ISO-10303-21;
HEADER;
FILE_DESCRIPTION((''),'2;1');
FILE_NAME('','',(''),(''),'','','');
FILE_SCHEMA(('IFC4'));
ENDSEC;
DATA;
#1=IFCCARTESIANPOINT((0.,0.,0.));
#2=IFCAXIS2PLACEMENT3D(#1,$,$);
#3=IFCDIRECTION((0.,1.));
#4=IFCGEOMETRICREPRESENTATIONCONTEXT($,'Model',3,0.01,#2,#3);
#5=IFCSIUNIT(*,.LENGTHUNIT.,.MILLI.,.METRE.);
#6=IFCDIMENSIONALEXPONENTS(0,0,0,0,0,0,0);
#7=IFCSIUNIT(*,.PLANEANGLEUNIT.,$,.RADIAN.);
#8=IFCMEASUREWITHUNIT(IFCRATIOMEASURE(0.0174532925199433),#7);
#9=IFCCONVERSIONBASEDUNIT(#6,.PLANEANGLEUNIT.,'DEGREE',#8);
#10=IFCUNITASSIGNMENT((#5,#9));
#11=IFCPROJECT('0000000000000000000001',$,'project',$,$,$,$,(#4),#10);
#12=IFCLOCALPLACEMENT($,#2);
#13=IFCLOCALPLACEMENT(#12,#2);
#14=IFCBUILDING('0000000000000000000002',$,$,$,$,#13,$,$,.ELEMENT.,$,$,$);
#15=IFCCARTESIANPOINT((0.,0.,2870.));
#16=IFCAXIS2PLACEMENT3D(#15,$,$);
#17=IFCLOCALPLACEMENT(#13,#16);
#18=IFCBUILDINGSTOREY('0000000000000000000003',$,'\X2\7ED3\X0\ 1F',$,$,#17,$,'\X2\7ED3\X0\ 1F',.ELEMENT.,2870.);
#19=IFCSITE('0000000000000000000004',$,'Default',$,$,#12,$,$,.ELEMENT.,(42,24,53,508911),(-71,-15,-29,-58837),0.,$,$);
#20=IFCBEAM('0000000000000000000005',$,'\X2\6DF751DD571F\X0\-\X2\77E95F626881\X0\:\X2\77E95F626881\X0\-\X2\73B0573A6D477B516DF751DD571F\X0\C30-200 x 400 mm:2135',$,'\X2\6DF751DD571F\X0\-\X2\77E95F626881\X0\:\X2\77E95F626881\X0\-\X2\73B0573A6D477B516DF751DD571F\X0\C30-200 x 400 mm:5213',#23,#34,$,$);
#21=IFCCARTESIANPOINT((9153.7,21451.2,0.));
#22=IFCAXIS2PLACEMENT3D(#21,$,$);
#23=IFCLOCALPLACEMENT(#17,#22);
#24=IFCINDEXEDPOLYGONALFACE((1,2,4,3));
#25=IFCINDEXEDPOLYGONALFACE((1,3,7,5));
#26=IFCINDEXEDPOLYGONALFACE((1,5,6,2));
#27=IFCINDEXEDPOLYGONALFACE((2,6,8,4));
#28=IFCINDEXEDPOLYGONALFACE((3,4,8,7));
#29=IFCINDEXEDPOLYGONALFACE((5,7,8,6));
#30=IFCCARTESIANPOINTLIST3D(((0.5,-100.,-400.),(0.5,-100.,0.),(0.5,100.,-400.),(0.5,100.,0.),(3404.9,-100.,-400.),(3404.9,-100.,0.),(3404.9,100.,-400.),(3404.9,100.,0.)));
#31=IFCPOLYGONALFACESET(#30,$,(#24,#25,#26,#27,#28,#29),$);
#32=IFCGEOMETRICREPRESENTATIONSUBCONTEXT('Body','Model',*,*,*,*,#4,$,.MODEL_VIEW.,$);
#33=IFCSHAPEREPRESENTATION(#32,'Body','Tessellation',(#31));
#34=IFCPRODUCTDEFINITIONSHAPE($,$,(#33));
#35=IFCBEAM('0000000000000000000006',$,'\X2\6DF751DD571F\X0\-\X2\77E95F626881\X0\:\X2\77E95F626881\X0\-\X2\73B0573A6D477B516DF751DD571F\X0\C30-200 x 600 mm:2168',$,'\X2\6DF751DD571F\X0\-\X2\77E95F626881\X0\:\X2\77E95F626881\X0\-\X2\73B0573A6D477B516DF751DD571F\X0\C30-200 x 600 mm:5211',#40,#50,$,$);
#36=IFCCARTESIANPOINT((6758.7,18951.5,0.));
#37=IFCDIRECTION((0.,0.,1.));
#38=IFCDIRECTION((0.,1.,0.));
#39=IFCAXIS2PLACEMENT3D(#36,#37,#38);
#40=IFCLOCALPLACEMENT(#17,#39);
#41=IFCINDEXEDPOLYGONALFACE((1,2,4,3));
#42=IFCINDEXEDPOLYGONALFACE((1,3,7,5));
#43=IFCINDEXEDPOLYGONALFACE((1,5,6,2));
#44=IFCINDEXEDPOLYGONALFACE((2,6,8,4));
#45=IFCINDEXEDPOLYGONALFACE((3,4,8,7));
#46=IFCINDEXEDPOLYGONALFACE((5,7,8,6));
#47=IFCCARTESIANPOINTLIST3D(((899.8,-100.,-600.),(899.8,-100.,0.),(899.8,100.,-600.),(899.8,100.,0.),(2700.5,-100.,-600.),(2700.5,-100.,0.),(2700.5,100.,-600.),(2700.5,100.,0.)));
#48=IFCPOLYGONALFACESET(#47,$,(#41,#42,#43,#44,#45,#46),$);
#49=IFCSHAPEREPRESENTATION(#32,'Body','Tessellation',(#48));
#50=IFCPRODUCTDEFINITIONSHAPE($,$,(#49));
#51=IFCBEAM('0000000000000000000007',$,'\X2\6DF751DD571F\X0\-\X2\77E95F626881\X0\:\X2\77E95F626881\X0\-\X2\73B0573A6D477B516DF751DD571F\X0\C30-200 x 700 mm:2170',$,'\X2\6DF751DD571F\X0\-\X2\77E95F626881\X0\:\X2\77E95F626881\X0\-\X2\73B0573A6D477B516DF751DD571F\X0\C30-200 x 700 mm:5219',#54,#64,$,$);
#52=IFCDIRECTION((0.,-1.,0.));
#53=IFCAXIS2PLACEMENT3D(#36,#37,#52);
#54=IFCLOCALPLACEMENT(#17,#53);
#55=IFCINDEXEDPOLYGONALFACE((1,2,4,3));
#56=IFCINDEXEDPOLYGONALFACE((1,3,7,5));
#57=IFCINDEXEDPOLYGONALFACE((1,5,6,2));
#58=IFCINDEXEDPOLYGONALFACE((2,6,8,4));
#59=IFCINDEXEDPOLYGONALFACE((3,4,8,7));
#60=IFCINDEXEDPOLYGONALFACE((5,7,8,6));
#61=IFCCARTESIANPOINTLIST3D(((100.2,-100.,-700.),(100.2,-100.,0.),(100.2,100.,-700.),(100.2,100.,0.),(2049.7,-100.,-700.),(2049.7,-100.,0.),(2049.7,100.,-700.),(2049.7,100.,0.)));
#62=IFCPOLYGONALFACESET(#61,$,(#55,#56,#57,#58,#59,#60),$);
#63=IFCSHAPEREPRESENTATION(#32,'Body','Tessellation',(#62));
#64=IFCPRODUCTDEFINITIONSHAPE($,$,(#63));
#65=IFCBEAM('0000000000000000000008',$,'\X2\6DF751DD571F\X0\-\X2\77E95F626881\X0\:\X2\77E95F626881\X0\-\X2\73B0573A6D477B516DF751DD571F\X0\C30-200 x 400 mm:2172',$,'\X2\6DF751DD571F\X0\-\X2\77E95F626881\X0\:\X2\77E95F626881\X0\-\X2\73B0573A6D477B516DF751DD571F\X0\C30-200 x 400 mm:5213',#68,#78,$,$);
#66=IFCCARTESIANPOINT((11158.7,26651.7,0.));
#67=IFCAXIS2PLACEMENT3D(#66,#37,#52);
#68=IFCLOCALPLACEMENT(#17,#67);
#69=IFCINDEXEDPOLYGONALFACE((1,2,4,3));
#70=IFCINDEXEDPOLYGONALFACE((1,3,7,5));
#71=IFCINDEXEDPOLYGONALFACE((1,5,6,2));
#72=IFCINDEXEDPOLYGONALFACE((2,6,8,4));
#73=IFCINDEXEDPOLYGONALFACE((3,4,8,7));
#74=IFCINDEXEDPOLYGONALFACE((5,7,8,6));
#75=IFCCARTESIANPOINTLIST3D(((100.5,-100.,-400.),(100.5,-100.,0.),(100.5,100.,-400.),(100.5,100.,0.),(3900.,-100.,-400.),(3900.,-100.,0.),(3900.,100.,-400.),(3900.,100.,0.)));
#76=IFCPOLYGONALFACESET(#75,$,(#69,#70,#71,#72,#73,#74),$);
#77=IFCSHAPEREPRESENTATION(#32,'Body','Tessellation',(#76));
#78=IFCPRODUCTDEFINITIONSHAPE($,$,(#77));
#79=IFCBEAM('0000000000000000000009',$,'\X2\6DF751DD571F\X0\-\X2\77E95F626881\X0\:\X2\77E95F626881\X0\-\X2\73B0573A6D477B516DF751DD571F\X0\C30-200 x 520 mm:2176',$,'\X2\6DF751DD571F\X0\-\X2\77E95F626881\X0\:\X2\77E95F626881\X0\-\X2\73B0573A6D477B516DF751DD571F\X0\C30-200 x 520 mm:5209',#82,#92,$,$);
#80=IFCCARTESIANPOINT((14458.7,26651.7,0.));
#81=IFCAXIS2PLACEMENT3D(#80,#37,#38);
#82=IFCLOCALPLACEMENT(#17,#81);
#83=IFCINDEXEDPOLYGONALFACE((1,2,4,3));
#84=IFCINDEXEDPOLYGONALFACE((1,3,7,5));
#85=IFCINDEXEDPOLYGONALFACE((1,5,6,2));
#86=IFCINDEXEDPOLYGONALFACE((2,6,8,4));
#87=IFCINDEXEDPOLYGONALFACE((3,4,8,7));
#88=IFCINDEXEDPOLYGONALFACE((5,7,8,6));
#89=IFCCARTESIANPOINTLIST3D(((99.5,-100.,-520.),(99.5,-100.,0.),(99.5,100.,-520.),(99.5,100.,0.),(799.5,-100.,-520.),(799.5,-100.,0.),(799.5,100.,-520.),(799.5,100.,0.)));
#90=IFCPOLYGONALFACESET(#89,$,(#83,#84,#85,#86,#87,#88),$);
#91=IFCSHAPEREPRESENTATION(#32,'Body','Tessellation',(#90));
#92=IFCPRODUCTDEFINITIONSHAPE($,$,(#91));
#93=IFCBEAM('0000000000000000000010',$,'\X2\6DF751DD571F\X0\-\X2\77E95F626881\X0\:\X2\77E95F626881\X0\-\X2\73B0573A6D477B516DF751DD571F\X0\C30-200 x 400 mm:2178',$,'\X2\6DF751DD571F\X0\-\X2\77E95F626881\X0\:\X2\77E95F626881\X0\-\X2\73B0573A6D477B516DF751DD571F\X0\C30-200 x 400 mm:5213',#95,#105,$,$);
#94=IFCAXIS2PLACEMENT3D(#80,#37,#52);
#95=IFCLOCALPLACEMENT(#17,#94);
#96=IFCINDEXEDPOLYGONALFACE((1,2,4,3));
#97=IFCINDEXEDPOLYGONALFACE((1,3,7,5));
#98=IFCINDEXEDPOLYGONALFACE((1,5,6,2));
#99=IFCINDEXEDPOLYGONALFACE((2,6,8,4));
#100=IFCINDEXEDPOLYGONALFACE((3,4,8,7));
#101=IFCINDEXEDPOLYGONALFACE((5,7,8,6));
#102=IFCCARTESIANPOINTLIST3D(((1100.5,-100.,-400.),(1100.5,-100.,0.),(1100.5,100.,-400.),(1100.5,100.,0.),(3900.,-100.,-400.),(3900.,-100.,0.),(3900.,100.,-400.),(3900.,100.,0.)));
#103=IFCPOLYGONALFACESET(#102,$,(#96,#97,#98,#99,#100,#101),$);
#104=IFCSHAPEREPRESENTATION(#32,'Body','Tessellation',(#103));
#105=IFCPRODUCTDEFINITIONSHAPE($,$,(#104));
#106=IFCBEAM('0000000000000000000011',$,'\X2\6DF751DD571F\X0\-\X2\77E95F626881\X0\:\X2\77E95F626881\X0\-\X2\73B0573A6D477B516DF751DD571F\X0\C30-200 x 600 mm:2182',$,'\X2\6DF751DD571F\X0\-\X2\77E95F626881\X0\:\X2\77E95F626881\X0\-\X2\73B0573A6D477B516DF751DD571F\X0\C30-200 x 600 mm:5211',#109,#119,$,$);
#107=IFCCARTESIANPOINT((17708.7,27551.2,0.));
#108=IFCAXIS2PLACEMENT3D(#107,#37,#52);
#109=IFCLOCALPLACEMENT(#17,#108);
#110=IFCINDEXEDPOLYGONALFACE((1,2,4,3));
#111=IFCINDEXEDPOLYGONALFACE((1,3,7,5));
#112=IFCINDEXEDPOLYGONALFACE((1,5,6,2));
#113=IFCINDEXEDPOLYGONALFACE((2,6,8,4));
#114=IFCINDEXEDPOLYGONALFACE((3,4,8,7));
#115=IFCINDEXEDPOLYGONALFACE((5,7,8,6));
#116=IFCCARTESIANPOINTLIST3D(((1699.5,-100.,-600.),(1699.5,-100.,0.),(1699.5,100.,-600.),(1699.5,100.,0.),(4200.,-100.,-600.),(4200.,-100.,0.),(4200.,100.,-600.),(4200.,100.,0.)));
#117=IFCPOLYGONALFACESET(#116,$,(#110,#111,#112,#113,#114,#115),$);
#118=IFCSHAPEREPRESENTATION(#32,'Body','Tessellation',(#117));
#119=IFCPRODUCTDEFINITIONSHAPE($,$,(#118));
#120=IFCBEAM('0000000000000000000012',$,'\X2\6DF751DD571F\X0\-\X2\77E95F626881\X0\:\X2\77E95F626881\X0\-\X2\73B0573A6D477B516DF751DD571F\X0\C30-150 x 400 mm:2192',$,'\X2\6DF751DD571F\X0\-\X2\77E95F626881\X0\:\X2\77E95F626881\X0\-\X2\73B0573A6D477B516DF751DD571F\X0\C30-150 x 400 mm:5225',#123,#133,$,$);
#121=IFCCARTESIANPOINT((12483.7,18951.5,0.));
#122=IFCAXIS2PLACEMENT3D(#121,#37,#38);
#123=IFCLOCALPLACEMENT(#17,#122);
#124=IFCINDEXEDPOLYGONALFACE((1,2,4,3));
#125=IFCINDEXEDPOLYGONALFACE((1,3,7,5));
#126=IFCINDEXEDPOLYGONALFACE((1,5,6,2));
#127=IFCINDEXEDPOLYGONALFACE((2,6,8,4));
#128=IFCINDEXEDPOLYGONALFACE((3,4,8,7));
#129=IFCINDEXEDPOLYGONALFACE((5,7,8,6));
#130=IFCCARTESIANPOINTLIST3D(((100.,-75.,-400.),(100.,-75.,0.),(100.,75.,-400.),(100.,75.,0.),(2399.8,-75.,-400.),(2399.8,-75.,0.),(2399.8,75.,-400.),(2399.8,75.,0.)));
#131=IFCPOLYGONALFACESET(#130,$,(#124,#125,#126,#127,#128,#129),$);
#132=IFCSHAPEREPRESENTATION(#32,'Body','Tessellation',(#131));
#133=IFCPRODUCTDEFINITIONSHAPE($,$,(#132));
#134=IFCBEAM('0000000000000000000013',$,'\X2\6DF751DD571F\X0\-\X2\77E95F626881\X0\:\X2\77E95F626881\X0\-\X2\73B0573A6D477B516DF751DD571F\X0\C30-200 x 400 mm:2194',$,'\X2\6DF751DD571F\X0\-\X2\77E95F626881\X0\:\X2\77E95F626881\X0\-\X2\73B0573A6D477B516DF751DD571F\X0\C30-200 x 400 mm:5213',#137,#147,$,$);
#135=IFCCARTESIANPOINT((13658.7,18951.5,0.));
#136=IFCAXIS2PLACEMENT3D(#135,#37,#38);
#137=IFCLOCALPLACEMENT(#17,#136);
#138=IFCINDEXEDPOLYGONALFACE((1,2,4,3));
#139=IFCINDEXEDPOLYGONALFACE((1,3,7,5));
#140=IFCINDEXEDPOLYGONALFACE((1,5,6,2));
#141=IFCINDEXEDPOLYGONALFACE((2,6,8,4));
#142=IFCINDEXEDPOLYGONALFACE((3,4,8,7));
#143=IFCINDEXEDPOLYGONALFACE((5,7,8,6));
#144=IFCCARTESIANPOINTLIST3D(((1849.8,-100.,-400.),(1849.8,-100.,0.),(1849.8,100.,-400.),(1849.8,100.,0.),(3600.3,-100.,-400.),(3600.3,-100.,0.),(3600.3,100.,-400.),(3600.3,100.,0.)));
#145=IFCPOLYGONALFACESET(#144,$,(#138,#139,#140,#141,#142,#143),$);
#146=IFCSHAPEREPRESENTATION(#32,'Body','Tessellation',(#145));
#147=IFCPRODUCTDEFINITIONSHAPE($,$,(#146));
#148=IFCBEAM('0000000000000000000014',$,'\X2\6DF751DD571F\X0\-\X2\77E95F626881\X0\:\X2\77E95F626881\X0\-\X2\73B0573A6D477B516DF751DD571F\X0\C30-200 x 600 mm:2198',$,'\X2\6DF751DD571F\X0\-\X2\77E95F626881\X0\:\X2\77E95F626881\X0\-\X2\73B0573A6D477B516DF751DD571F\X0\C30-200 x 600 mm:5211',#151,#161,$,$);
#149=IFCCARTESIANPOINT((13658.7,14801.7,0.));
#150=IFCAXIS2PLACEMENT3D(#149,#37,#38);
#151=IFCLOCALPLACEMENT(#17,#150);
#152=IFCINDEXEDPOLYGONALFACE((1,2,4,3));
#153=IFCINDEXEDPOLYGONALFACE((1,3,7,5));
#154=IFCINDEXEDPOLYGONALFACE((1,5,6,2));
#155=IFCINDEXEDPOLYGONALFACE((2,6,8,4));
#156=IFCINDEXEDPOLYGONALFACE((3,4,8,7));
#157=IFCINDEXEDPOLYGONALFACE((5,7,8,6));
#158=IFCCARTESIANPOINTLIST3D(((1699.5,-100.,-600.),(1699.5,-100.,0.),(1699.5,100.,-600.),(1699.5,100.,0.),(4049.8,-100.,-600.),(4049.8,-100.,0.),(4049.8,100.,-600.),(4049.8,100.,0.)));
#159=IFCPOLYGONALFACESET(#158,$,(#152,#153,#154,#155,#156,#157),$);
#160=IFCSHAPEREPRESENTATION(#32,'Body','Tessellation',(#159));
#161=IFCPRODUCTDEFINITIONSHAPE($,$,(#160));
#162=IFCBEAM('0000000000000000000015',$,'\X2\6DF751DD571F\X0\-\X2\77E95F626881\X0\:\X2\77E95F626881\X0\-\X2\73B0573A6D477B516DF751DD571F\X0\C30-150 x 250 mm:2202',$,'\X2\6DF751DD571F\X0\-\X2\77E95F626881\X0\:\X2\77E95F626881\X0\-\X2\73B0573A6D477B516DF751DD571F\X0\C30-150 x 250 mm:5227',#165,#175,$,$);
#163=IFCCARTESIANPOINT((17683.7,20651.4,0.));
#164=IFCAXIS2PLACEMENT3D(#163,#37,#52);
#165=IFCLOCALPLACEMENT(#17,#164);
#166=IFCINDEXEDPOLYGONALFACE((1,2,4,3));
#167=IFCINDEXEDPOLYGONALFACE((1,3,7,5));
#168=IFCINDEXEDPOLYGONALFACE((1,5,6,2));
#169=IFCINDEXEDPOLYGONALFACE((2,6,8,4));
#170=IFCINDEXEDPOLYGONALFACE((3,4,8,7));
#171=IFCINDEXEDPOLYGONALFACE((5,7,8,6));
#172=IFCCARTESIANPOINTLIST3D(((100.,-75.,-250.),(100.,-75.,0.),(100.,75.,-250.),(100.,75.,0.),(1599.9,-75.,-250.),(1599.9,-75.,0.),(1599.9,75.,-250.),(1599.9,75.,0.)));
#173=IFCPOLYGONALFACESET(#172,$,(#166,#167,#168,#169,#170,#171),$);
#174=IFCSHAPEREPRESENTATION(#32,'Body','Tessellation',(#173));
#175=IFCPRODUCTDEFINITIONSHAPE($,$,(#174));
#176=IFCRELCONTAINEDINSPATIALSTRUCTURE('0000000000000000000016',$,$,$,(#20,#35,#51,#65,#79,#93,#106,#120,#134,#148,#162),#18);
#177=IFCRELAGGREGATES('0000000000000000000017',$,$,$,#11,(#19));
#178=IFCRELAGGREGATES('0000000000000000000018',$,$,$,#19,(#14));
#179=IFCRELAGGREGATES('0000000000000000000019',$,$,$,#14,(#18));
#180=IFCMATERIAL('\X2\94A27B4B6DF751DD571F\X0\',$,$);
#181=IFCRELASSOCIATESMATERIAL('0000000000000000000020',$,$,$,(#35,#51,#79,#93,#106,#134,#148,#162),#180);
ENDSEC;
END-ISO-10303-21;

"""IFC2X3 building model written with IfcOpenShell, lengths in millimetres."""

from ifc_helpers import new_model, entity, si_unit, converted_unit, direction, frame, frame_2d, origin, place, context, subcontext, project, spatial, rectangle, extrude, material, element, save


model = new_model("IFC2X3")

# Units and contexts
model_context = context("Model", 3, precision=0.01, world=origin(), true_north=direction((0.0, 1.0)))
body_context = subcontext(model_context, "Body", "Model", "MODEL_VIEW")
ifc_project = project(units=[si_unit("LENGTHUNIT", "METRE", prefix="MILLI"), converted_unit("PLANEANGLEUNIT", "DEGREE", entity("IfcRatioMeasure", 0.0174532925199433), si_unit("PLANEANGLEUNIT", "RADIAN"), dimensions=[0, 0, 0, 0, 0, 0, 0])], contexts=[model_context])

# Site, building, storey
site_placement = place(None, origin())
site = spatial("IfcSite", under=ifc_project, at=site_placement, Name="Default", CompositionType="ELEMENT", RefLatitude=(42, 24, 53, 508911), RefLongitude=(-71, -15, -29, -58837), RefElevation=0.0)
building_placement = place(site_placement, origin())
building = spatial("IfcBuilding", under=site, at=building_placement, CompositionType="ELEMENT")
storey_placement = place(building_placement, frame((0.0, 0.0, 2870.0)))
storey = spatial("IfcBuildingStorey", under=building, at=storey_placement, Name="结 1F", LongName="结 1F", CompositionType="ELEMENT", Elevation=2870.0)

# Beams
ifc_material = material(Name="钢筋混凝土")
beam_1_placement = place(storey_placement, frame((9153.7, 21451.2, 0.0)))
element("IfcBeam", 1, at=beam_1_placement, inside=storey, Name="混凝土-矩形梁:矩形梁-现场浇筑混凝土C30-200 x 400 mm:2135", ObjectType="混凝土-矩形梁:矩形梁-现场浇筑混凝土C30-200 x 400 mm:5213", context=body_context, shape_type="SweptSolid", body=[
    extrude(rectangle(XDim=400.0, YDim=200.0, at=frame_2d((0.0, 0.0), x_axis=(1.0, 0.0))), frame((0.5, 0.0, -200.0), z_axis=(1.0, 0.0, 0.0), x_axis=(0.0, 0.0, -1.0)), (0.0, 0.0, 1.0), 3404.5),
])
beam_2_placement = place(storey_placement, frame((6758.7, 18951.5, 0.0), z_axis=(0.0, 0.0, 1.0), x_axis=(0.0, 1.0, 0.0)))
element("IfcBeam", 2, at=beam_2_placement, inside=storey, material=ifc_material, Name="混凝土-矩形梁:矩形梁-现场浇筑混凝土C30-200 x 600 mm:2168", ObjectType="混凝土-矩形梁:矩形梁-现场浇筑混凝土C30-200 x 600 mm:5211", context=body_context, shape_type="SweptSolid", body=[
    extrude(rectangle(XDim=600.0, YDim=200.0, at=frame_2d((0.0, 0.0), x_axis=(1.0, 0.0))), frame((899.8, 0.0, -300.0), z_axis=(1.0, 0.0, 0.0), x_axis=(0.0, 0.0, -1.0)), (0.0, 0.0, 1.0), 1800.7),
])
beam_3_placement = place(storey_placement, frame((6758.7, 18951.5, 0.0), z_axis=(0.0, 0.0, 1.0), x_axis=(0.0, -1.0, 0.0)))
element("IfcBeam", 3, at=beam_3_placement, inside=storey, material=ifc_material, Name="混凝土-矩形梁:矩形梁-现场浇筑混凝土C30-200 x 700 mm:2170", ObjectType="混凝土-矩形梁:矩形梁-现场浇筑混凝土C30-200 x 700 mm:5219", context=body_context, shape_type="SweptSolid", body=[
    extrude(rectangle(XDim=700.0, YDim=200.0, at=frame_2d((0.0, 0.0), x_axis=(1.0, 0.0))), frame((100.2, 0.0, -350.0), z_axis=(1.0, 0.0, 0.0), x_axis=(0.0, 0.0, -1.0)), (0.0, 0.0, 1.0), 1949.5),
])
beam_4_placement = place(storey_placement, frame((11158.7, 26651.7, 0.0), z_axis=(0.0, 0.0, 1.0), x_axis=(0.0, -1.0, 0.0)))
element("IfcBeam", 4, at=beam_4_placement, inside=storey, Name="混凝土-矩形梁:矩形梁-现场浇筑混凝土C30-200 x 400 mm:2172", ObjectType="混凝土-矩形梁:矩形梁-现场浇筑混凝土C30-200 x 400 mm:5213", context=body_context, shape_type="SweptSolid", body=[
    extrude(rectangle(XDim=400.0, YDim=200.0, at=frame_2d((0.0, 0.0), x_axis=(1.0, 0.0))), frame((100.5, 0.0, -200.0), z_axis=(1.0, 0.0, 0.0), x_axis=(0.0, 0.0, -1.0)), (0.0, 0.0, 1.0), 3799.5),
])
beam_5_placement = place(storey_placement, frame((14458.7, 26651.7, 0.0), z_axis=(0.0, 0.0, 1.0), x_axis=(0.0, 1.0, 0.0)))
element("IfcBeam", 5, at=beam_5_placement, inside=storey, material=ifc_material, Name="混凝土-矩形梁:矩形梁-现场浇筑混凝土C30-200 x 520 mm:2176", ObjectType="混凝土-矩形梁:矩形梁-现场浇筑混凝土C30-200 x 520 mm:5209", context=body_context, shape_type="SweptSolid", body=[
    extrude(rectangle(XDim=520.0, YDim=200.0, at=frame_2d((0.0, 0.0), x_axis=(1.0, 0.0))), frame((99.5, 0.0, -260.0), z_axis=(1.0, 0.0, 0.0), x_axis=(0.0, 0.0, -1.0)), (0.0, 0.0, 1.0), 700.0),
])
beam_6_placement = place(storey_placement, frame((14458.7, 26651.7, 0.0), z_axis=(0.0, 0.0, 1.0), x_axis=(0.0, -1.0, 0.0)))
element("IfcBeam", 6, at=beam_6_placement, inside=storey, material=ifc_material, Name="混凝土-矩形梁:矩形梁-现场浇筑混凝土C30-200 x 400 mm:2178", ObjectType="混凝土-矩形梁:矩形梁-现场浇筑混凝土C30-200 x 400 mm:5213", context=body_context, shape_type="SweptSolid", body=[
    extrude(rectangle(XDim=400.0, YDim=200.0, at=frame_2d((0.0, 0.0), x_axis=(1.0, 0.0))), frame((1100.5, 0.0, -200.0), z_axis=(1.0, 0.0, 0.0), x_axis=(0.0, 0.0, -1.0)), (0.0, 0.0, 1.0), 2799.5),
])
beam_7_placement = place(storey_placement, frame((17708.7, 27551.2, 0.0), z_axis=(0.0, 0.0, 1.0), x_axis=(0.0, -1.0, 0.0)))
element("IfcBeam", 7, at=beam_7_placement, inside=storey, material=ifc_material, Name="混凝土-矩形梁:矩形梁-现场浇筑混凝土C30-200 x 600 mm:2182", ObjectType="混凝土-矩形梁:矩形梁-现场浇筑混凝土C30-200 x 600 mm:5211", context=body_context, shape_type="SweptSolid", body=[
    extrude(rectangle(XDim=600.0, YDim=200.0, at=frame_2d((0.0, 0.0), x_axis=(1.0, 0.0))), frame((1699.5, 0.0, -300.0), z_axis=(1.0, 0.0, 0.0), x_axis=(0.0, 0.0, -1.0)), (0.0, 0.0, 1.0), 2500.5),
])
beam_8_placement = place(storey_placement, frame((12483.7, 18951.5, 0.0), z_axis=(0.0, 0.0, 1.0), x_axis=(0.0, 1.0, 0.0)))
element("IfcBeam", 8, at=beam_8_placement, inside=storey, Name="混凝土-矩形梁:矩形梁-现场浇筑混凝土C30-150 x 400 mm:2192", ObjectType="混凝土-矩形梁:矩形梁-现场浇筑混凝土C30-150 x 400 mm:5225", context=body_context, shape_type="SweptSolid", body=[
    extrude(rectangle(XDim=400.0, YDim=150.0, at=frame_2d((0.0, 0.0), x_axis=(1.0, 0.0))), frame((100.0, 0.0, -200.0), z_axis=(1.0, 0.0, 0.0), x_axis=(0.0, 0.0, -1.0)), (0.0, 0.0, 1.0), 2299.8),
])
beam_9_placement = place(storey_placement, frame((13658.7, 18951.5, 0.0), z_axis=(0.0, 0.0, 1.0), x_axis=(0.0, 1.0, 0.0)))
element("IfcBeam", 9, at=beam_9_placement, inside=storey, material=ifc_material, Name="混凝土-矩形梁:矩形梁-现场浇筑混凝土C30-200 x 400 mm:2194", ObjectType="混凝土-矩形梁:矩形梁-现场浇筑混凝土C30-200 x 400 mm:5213", context=body_context, shape_type="SweptSolid", body=[
    extrude(rectangle(XDim=400.0, YDim=200.0, at=frame_2d((0.0, 0.0), x_axis=(1.0, 0.0))), frame((1849.8, 0.0, -200.0), z_axis=(1.0, 0.0, 0.0), x_axis=(0.0, 0.0, -1.0)), (0.0, 0.0, 1.0), 1750.5),
])
beam_10_placement = place(storey_placement, frame((13658.7, 14801.7, 0.0), z_axis=(0.0, 0.0, 1.0), x_axis=(0.0, 1.0, 0.0)))
element("IfcBeam", 10, at=beam_10_placement, inside=storey, material=ifc_material, Name="混凝土-矩形梁:矩形梁-现场浇筑混凝土C30-200 x 600 mm:2198", ObjectType="混凝土-矩形梁:矩形梁-现场浇筑混凝土C30-200 x 600 mm:5211", context=body_context, shape_type="SweptSolid", body=[
    extrude(rectangle(XDim=600.0, YDim=200.0, at=frame_2d((0.0, 0.0), x_axis=(1.0, 0.0))), frame((1699.5, 0.0, -300.0), z_axis=(1.0, 0.0, 0.0), x_axis=(0.0, 0.0, -1.0)), (0.0, 0.0, 1.0), 2350.2),
])
beam_11_placement = place(storey_placement, frame((17683.7, 20651.4, 0.0), z_axis=(0.0, 0.0, 1.0), x_axis=(0.0, -1.0, 0.0)))
element("IfcBeam", 11, at=beam_11_placement, inside=storey, material=ifc_material, Name="混凝土-矩形梁:矩形梁-现场浇筑混凝土C30-150 x 250 mm:2202", ObjectType="混凝土-矩形梁:矩形梁-现场浇筑混凝土C30-150 x 250 mm:5227", context=body_context, shape_type="SweptSolid", body=[
    extrude(rectangle(XDim=250.0, YDim=150.0, at=frame_2d((0.0, 0.0), x_axis=(1.0, 0.0))), frame((100.0, 0.0, -125.0), z_axis=(1.0, 0.0, 0.0), x_axis=(0.0, 0.0, -1.0)), (0.0, 0.0, 1.0), 1499.9),
])

save(model, "model.ifc")
